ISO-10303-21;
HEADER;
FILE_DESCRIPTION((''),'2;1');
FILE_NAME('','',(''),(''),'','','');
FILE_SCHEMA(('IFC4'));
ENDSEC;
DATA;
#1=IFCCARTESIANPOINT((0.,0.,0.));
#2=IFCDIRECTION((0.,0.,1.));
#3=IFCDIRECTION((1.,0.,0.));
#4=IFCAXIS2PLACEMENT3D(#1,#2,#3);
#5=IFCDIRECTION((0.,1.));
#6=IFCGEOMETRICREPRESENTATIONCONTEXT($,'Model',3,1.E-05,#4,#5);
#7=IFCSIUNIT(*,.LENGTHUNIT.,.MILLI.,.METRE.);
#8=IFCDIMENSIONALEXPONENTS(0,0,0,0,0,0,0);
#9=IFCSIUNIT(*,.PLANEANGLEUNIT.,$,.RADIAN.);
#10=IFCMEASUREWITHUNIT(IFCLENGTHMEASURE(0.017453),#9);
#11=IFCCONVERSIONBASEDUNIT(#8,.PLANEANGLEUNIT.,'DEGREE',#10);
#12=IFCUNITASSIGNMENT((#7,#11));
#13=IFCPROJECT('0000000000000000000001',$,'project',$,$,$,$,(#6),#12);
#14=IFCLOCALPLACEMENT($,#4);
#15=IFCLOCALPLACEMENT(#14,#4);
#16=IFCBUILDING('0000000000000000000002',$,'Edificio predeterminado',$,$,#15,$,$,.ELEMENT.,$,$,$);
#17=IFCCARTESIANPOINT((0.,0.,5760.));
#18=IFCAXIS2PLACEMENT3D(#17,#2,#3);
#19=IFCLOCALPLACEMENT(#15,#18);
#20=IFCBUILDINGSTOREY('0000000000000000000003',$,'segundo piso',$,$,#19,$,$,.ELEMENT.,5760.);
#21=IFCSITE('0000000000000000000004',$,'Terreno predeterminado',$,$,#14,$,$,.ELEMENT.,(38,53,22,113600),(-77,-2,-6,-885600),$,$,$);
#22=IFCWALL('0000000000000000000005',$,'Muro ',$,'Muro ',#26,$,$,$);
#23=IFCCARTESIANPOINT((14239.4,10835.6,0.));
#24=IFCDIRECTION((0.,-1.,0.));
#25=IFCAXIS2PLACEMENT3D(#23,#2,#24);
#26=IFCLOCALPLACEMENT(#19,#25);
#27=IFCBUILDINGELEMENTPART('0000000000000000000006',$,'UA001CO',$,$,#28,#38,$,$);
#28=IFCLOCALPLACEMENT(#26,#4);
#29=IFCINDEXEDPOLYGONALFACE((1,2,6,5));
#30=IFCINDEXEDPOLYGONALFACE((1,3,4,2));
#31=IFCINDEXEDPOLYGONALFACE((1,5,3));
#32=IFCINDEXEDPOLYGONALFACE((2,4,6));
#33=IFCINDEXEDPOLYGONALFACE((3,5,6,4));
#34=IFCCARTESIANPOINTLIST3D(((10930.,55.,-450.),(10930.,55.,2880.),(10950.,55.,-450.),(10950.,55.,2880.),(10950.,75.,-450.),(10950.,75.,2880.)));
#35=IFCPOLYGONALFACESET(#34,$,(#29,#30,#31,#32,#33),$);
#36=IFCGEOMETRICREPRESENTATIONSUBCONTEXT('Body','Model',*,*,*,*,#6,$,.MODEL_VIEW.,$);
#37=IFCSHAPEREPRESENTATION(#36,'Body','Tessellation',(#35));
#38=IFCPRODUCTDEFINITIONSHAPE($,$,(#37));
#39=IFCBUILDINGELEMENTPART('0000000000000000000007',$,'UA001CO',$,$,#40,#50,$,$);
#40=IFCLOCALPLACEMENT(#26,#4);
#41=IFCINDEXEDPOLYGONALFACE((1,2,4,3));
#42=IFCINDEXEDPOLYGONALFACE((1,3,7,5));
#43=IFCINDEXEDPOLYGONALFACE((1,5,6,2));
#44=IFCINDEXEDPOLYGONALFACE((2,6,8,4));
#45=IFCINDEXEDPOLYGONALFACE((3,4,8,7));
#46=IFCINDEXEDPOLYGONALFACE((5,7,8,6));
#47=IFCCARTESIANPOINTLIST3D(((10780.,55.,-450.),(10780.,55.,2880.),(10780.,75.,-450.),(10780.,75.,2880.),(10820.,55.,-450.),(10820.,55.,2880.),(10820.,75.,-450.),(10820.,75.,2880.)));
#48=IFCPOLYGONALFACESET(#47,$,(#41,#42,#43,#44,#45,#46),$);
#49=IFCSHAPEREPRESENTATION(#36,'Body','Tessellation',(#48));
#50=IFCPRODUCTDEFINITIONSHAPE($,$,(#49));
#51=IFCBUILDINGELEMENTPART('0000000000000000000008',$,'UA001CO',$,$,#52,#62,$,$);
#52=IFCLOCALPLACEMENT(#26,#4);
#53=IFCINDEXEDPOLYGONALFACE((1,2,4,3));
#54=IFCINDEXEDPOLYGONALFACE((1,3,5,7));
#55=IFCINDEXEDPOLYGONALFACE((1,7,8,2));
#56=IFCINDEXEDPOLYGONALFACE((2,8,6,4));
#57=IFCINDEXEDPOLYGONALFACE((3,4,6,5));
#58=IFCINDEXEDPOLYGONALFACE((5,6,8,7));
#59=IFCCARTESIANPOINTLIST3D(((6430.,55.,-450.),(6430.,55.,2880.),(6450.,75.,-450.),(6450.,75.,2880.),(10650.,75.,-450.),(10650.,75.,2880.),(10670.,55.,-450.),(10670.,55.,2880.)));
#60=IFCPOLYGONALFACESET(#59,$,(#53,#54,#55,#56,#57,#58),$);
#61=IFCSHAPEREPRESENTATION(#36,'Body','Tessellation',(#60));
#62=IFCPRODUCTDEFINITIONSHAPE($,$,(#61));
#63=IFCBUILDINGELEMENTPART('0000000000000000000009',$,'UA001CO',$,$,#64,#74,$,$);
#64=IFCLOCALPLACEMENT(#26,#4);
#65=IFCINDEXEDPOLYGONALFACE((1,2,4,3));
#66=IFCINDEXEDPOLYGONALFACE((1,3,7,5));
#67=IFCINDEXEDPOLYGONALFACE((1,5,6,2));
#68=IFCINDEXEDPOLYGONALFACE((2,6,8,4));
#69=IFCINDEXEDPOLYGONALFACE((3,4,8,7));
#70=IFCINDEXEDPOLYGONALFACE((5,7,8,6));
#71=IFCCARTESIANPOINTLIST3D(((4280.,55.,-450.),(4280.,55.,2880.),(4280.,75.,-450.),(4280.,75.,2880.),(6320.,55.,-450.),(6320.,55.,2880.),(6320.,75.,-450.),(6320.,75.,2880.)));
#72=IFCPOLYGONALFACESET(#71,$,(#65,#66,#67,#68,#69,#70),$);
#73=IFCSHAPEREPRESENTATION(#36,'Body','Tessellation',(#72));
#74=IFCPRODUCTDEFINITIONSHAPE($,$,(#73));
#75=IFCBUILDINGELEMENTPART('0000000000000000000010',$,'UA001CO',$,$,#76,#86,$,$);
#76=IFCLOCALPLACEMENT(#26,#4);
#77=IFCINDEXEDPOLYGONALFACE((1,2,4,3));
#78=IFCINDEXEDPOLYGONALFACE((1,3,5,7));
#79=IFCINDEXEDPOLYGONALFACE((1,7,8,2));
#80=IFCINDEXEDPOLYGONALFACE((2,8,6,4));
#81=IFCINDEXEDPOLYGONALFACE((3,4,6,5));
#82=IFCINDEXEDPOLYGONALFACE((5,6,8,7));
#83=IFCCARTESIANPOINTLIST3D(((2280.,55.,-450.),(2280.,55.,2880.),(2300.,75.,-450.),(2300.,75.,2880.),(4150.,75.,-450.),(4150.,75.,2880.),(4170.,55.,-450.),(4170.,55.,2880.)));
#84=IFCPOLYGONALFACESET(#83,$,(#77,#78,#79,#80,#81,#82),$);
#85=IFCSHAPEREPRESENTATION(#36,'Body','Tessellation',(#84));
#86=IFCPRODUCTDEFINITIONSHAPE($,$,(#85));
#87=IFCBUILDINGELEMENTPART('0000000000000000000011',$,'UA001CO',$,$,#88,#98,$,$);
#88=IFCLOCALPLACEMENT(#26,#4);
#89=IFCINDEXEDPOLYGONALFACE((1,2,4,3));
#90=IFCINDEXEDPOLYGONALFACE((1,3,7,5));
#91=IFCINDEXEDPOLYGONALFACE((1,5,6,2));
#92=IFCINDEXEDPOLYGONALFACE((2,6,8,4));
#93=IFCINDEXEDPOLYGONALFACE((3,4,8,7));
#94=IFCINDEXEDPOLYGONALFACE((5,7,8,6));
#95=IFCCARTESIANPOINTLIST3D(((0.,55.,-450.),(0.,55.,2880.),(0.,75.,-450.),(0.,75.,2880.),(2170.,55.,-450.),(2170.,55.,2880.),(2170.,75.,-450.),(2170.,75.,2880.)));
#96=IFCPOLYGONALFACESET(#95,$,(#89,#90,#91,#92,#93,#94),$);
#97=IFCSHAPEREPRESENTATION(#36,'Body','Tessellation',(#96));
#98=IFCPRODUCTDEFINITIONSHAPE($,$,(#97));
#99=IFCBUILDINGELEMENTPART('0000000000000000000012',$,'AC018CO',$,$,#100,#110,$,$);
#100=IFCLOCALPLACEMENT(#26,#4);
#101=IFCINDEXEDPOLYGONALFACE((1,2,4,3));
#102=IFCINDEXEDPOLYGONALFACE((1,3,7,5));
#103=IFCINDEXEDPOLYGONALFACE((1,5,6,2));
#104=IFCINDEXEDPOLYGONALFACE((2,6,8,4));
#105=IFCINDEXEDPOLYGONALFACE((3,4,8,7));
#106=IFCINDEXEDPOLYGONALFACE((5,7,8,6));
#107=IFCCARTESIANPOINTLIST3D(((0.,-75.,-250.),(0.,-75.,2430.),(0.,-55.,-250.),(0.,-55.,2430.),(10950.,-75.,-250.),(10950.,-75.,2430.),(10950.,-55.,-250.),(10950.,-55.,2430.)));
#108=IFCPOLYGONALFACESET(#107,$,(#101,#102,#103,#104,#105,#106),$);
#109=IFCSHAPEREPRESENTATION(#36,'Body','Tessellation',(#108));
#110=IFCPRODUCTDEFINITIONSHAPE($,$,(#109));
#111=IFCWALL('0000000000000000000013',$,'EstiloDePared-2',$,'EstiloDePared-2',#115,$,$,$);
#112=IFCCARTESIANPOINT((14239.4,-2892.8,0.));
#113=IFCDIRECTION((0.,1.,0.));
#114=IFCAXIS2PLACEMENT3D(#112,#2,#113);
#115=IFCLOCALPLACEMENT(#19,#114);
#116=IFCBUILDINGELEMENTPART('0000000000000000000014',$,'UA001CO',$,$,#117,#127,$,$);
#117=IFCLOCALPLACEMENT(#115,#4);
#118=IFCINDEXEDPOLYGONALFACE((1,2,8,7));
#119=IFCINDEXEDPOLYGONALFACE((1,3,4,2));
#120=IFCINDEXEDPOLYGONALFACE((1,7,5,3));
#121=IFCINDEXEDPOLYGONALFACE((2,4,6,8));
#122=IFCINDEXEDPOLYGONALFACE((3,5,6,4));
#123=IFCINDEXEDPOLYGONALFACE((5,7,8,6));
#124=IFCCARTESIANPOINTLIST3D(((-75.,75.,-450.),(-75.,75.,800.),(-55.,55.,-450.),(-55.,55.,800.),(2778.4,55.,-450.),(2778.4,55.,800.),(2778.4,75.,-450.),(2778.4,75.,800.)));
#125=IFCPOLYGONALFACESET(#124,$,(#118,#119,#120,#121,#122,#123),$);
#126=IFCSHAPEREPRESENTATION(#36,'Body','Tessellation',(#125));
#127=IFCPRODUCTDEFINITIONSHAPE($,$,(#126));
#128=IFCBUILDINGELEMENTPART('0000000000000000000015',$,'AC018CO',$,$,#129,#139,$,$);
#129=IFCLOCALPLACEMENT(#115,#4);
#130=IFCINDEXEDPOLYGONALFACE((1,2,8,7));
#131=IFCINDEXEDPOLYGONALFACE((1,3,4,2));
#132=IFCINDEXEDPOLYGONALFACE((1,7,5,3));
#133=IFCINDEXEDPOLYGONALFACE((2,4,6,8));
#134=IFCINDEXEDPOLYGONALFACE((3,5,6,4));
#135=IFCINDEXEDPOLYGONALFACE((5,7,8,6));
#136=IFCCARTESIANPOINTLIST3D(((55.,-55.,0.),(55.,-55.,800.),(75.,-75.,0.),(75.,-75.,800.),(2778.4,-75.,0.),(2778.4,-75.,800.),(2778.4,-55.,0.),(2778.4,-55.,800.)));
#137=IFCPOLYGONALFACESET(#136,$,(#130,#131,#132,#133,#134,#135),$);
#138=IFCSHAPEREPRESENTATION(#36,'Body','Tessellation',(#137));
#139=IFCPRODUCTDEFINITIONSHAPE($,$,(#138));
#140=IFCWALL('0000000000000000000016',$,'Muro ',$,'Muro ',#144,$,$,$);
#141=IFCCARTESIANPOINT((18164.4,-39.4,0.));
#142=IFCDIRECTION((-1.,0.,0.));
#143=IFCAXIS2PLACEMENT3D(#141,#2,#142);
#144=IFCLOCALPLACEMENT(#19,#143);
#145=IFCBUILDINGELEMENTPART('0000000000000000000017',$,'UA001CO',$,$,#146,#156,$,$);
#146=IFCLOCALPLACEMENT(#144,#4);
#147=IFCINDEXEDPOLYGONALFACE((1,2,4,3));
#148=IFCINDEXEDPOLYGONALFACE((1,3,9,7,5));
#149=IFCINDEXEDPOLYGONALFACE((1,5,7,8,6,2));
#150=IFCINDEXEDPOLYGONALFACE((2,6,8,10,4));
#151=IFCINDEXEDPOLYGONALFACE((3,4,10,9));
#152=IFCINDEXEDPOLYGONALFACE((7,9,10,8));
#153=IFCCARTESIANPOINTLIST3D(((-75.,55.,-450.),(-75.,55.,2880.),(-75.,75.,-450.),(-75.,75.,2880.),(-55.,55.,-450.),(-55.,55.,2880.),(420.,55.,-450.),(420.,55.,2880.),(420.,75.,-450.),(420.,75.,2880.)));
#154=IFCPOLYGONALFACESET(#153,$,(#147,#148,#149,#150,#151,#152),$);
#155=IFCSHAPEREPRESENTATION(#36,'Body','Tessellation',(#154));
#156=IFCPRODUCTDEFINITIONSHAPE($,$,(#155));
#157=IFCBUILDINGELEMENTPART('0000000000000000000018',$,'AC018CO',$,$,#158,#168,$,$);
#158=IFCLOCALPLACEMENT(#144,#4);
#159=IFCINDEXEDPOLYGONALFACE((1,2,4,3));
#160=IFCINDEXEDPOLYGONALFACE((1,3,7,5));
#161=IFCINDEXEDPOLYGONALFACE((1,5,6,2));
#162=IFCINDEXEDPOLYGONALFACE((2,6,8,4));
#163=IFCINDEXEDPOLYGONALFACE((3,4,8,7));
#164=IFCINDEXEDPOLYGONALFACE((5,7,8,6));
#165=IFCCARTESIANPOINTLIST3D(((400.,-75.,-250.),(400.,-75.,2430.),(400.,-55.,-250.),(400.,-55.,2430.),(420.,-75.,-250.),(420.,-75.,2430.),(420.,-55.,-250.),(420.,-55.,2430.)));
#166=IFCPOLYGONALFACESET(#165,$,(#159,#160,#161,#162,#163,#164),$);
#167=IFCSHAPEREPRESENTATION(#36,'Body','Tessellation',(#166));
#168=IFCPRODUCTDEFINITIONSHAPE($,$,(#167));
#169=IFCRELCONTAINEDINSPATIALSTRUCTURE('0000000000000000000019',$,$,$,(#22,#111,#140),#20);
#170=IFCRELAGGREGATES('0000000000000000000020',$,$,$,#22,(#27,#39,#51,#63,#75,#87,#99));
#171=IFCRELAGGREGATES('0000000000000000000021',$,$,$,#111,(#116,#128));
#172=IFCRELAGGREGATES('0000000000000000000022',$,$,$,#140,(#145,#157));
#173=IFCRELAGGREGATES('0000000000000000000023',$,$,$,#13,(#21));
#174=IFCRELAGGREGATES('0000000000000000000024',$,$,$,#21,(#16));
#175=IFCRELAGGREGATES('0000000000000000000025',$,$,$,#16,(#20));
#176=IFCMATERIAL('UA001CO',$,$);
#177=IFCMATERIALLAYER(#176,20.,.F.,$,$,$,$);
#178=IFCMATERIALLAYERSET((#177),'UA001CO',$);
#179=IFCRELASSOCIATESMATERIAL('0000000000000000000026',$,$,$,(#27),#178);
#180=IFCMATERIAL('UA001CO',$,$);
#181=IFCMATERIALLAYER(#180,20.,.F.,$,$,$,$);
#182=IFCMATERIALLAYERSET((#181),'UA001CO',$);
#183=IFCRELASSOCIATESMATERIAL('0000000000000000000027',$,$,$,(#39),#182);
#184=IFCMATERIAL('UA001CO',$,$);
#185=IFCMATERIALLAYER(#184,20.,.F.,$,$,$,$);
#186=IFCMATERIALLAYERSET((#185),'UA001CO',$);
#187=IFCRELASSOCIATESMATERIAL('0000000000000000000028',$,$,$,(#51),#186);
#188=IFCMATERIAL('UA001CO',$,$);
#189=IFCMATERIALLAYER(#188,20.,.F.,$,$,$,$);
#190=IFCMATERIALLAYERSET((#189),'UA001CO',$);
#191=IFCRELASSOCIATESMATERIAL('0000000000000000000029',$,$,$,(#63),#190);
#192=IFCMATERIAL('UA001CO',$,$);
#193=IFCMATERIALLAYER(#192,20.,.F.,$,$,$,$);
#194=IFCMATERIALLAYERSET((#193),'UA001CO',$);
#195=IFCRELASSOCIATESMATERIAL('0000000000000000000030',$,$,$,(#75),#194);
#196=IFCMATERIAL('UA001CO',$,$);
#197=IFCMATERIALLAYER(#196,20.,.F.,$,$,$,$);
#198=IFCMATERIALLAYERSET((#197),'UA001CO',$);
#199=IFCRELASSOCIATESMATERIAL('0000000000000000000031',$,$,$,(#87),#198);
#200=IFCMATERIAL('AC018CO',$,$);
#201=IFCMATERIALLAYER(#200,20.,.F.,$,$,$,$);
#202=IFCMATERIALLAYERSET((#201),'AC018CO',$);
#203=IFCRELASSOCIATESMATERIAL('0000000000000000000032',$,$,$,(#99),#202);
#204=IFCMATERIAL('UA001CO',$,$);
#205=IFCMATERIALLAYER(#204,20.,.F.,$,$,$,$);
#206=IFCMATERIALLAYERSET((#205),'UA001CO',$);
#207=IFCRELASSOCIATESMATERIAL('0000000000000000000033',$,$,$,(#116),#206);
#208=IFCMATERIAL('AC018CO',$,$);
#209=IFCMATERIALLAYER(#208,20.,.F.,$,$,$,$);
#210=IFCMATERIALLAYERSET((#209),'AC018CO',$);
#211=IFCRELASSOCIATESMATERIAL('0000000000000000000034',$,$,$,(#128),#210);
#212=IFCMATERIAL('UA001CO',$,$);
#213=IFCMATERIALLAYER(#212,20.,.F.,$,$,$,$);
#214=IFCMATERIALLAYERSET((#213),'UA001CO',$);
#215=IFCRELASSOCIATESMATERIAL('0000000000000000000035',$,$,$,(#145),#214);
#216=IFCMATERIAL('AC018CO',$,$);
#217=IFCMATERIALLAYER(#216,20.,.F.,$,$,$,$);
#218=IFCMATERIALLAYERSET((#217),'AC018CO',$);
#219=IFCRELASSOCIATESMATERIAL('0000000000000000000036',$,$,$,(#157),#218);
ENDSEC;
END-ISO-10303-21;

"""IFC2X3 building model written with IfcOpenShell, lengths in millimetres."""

from ifc_helpers import new_model, entity, si_unit, converted_unit, direction, frame, origin_with_axes, place, context, subcontext, project, spatial, polyline, outline, extrude, material, layer, layer_set, layer_usage, element, aggregate, save


model = new_model("IFC2X3")

# Units and contexts
model_context = context("Model", 3, precision=1e-05, world=origin_with_axes(), true_north=direction((0.0, 1.0)))
body_context = subcontext(model_context, "Body", "Model", "MODEL_VIEW")
ifc_project = project(units=[si_unit("LENGTHUNIT", "METRE", prefix="MILLI"), converted_unit("PLANEANGLEUNIT", "DEGREE", entity("IfcLengthMeasure", 0.017453), si_unit("PLANEANGLEUNIT", "RADIAN"), dimensions=[0, 0, 0, 0, 0, 0, 0])], contexts=[model_context])

# Site, building, storey
site_placement = place(None, origin_with_axes())
site = spatial("IfcSite", under=ifc_project, at=site_placement, Name="Terreno predeterminado", CompositionType="ELEMENT", RefLatitude=(38, 53, 22, 113600), RefLongitude=(-77, -2, -6, -885600))
building_placement = place(site_placement, origin_with_axes())
building = spatial("IfcBuilding", under=site, at=building_placement, Name="Edificio predeterminado", CompositionType="ELEMENT")
storey_placement = place(building_placement, frame((0.0, 0.0, 5760.0), z_axis=(0.0, 0.0, 1.0), x_axis=(1.0, 0.0, 0.0)))
storey = spatial("IfcBuildingStorey", under=building, at=storey_placement, Name="segundo piso", CompositionType="ELEMENT", Elevation=5760.0)

# Walls, building element parts
wall_1_placement = place(storey_placement, frame((14239.4, 10835.6, 0.0), z_axis=(0.0, 0.0, 1.0), x_axis=(0.0, -1.0, 0.0)))
wall_1 = element("IfcWall", 1, at=wall_1_placement, inside=storey, Name="Muro ", ObjectType="Muro ")
ifc_material_1 = material(Name="UA001CO")
ifc_layer_1 = layer(ifc_material_1, 20.0, ventilated=False)
ifc_layer_set_1 = layer_set([ifc_layer_1], Name="UA001CO")
ifc_layer_usage_1 = layer_usage(ifc_layer_set_1, "AXIS2", "NEGATIVE", -75.0)
building_element_part_1_placement = place(wall_1_placement, origin_with_axes())
building_element_part_1 = element("IfcBuildingElementPart", 2, at=building_element_part_1_placement, material=ifc_layer_usage_1, Name="UA001CO", context=body_context, shape_type="SweptSolid", body=[
    extrude(outline(polyline([(10950.0, 75.0), (10950.0, 55.0), (10930.0, 55.0), (10950.0, 75.0)])), frame((0.0, 0.0, -450.0), z_axis=(0.0, 0.0, 1.0), x_axis=(1.0, 0.0, 0.0)), (0.0, 0.0, 1.0), 3330.0),
])
ifc_material_2 = material(Name="UA001CO")
ifc_layer_2 = layer(ifc_material_2, 20.0, ventilated=False)
ifc_layer_set_2 = layer_set([ifc_layer_2], Name="UA001CO")
ifc_layer_usage_2 = layer_usage(ifc_layer_set_2, "AXIS2", "NEGATIVE", -75.0)
building_element_part_2_placement = place(wall_1_placement, origin_with_axes())
building_element_part_2 = element("IfcBuildingElementPart", 3, at=building_element_part_2_placement, material=ifc_layer_usage_2, Name="UA001CO", context=body_context, shape_type="SweptSolid", body=[
    extrude(outline(polyline([(10820.0, 75.0), (10820.0, 55.0), (10780.0, 55.0), (10780.0, 75.0), (10820.0, 75.0)])), frame((0.0, 0.0, -450.0), z_axis=(0.0, 0.0, 1.0), x_axis=(1.0, 0.0, 0.0)), (0.0, 0.0, 1.0), 3330.0),
])
ifc_material_3 = material(Name="UA001CO")
ifc_layer_3 = layer(ifc_material_3, 20.0, ventilated=False)
ifc_layer_set_3 = layer_set([ifc_layer_3], Name="UA001CO")
ifc_layer_usage_3 = layer_usage(ifc_layer_set_3, "AXIS2", "NEGATIVE", -75.0)
building_element_part_3_placement = place(wall_1_placement, origin_with_axes())
building_element_part_3 = element("IfcBuildingElementPart", 4, at=building_element_part_3_placement, material=ifc_layer_usage_3, Name="UA001CO", context=body_context, shape_type="SweptSolid", body=[
    extrude(outline(polyline([(10650.0, 75.0), (10670.0, 55.0), (6430.0, 55.0), (6450.0, 75.0), (10650.0, 75.0)])), frame((0.0, 0.0, -450.0), z_axis=(0.0, 0.0, 1.0), x_axis=(1.0, 0.0, 0.0)), (0.0, 0.0, 1.0), 3330.0),
])
ifc_material_4 = material(Name="UA001CO")
ifc_layer_4 = layer(ifc_material_4, 20.0, ventilated=False)
ifc_layer_set_4 = layer_set([ifc_layer_4], Name="UA001CO")
ifc_layer_usage_4 = layer_usage(ifc_layer_set_4, "AXIS2", "NEGATIVE", -75.0)
building_element_part_4_placement = place(wall_1_placement, origin_with_axes())
building_element_part_4 = element("IfcBuildingElementPart", 5, at=building_element_part_4_placement, material=ifc_layer_usage_4, Name="UA001CO", context=body_context, shape_type="SweptSolid", body=[
    extrude(outline(polyline([(4280.0, 75.0), (6320.0, 75.0), (6320.0, 55.0), (4280.0, 55.0), (4280.0, 75.0)])), frame((0.0, 0.0, -450.0), z_axis=(0.0, 0.0, 1.0), x_axis=(1.0, 0.0, 0.0)), (0.0, 0.0, 1.0), 3330.0),
])
ifc_material_5 = material(Name="UA001CO")
ifc_layer_5 = layer(ifc_material_5, 20.0, ventilated=False)
ifc_layer_set_5 = layer_set([ifc_layer_5], Name="UA001CO")
ifc_layer_usage_5 = layer_usage(ifc_layer_set_5, "AXIS2", "NEGATIVE", -75.0)
building_element_part_5_placement = place(wall_1_placement, origin_with_axes())
building_element_part_5 = element("IfcBuildingElementPart", 6, at=building_element_part_5_placement, material=ifc_layer_usage_5, Name="UA001CO", context=body_context, shape_type="SweptSolid", body=[
    extrude(outline(polyline([(4150.0, 75.0), (4170.0, 55.0), (2280.0, 55.0), (2300.0, 75.0), (4150.0, 75.0)])), frame((0.0, 0.0, -450.0), z_axis=(0.0, 0.0, 1.0), x_axis=(1.0, 0.0, 0.0)), (0.0, 0.0, 1.0), 3330.0),
])
ifc_material_6 = material(Name="UA001CO")
ifc_layer_6 = layer(ifc_material_6, 20.0, ventilated=False)
ifc_layer_set_6 = layer_set([ifc_layer_6], Name="UA001CO")
ifc_layer_usage_6 = layer_usage(ifc_layer_set_6, "AXIS2", "NEGATIVE", -75.0)
building_element_part_6_placement = place(wall_1_placement, origin_with_axes())
building_element_part_6 = element("IfcBuildingElementPart", 7, at=building_element_part_6_placement, material=ifc_layer_usage_6, Name="UA001CO", context=body_context, shape_type="SweptSolid", body=[
    extrude(outline(polyline([(2170.0, 75.0), (2170.0, 55.0), (0.0, 55.0), (0.0, 75.0), (2170.0, 75.0)])), frame((0.0, 0.0, -450.0), z_axis=(0.0, 0.0, 1.0), x_axis=(1.0, 0.0, 0.0)), (0.0, 0.0, 1.0), 3330.0),
])
ifc_material_7 = material(Name="AC018CO")
ifc_layer_7 = layer(ifc_material_7, 20.0, ventilated=False)
ifc_layer_set_7 = layer_set([ifc_layer_7], Name="AC018CO")
ifc_layer_usage_7 = layer_usage(ifc_layer_set_7, "AXIS2", "NEGATIVE", 55.0)
building_element_part_7_placement = place(wall_1_placement, origin_with_axes())
building_element_part_7 = element("IfcBuildingElementPart", 8, at=building_element_part_7_placement, material=ifc_layer_usage_7, Name="AC018CO", context=body_context, shape_type="SweptSolid", body=[
    extrude(outline(polyline([(10950.0, -55.0), (10950.0, -75.0), (0.0, -75.0), (0.0, -55.0), (10950.0, -55.0)])), frame((0.0, 0.0, -250.0), z_axis=(0.0, 0.0, 1.0), x_axis=(1.0, 0.0, 0.0)), (0.0, 0.0, 1.0), 2680.0),
])
aggregate(wall_1, [building_element_part_1, building_element_part_2, building_element_part_3, building_element_part_4, building_element_part_5, building_element_part_6, building_element_part_7])
wall_2_placement = place(storey_placement, frame((14239.4, -2892.8, 0.0), z_axis=(0.0, 0.0, 1.0), x_axis=(0.0, 1.0, 0.0)))
wall_2 = element("IfcWall", 9, at=wall_2_placement, inside=storey, Name="EstiloDePared-2", ObjectType="EstiloDePared-2")
ifc_material_8 = material(Name="UA001CO")
ifc_layer_8 = layer(ifc_material_8, 20.0, ventilated=False)
ifc_layer_set_8 = layer_set([ifc_layer_8], Name="UA001CO")
ifc_layer_usage_8 = layer_usage(ifc_layer_set_8, "AXIS2", "NEGATIVE", -75.0)
building_element_part_8_placement = place(wall_2_placement, origin_with_axes())
building_element_part_8 = element("IfcBuildingElementPart", 10, at=building_element_part_8_placement, material=ifc_layer_usage_8, Name="UA001CO", context=body_context, shape_type="SweptSolid", body=[
    extrude(outline(polyline([(2778.4, 75.0), (2778.4, 55.0), (-55.0, 55.0), (-75.0, 75.0), (2778.4, 75.0)])), frame((0.0, 0.0, -450.0), z_axis=(0.0, 0.0, 1.0), x_axis=(1.0, 0.0, 0.0)), (0.0, 0.0, 1.0), 1250.0),
])
ifc_material_9 = material(Name="AC018CO")
ifc_layer_9 = layer(ifc_material_9, 20.0, ventilated=False)
ifc_layer_set_9 = layer_set([ifc_layer_9], Name="AC018CO")
ifc_layer_usage_9 = layer_usage(ifc_layer_set_9, "AXIS2", "NEGATIVE", 55.0)
building_element_part_9_placement = place(wall_2_placement, origin_with_axes())
building_element_part_9 = element("IfcBuildingElementPart", 11, at=building_element_part_9_placement, material=ifc_layer_usage_9, Name="AC018CO", context=body_context, shape_type="SweptSolid", body=[
    extrude(outline(polyline([(2778.4, -55.0), (2778.4, -75.0), (75.0, -75.0), (55.0, -55.0), (2778.4, -55.0)])), origin_with_axes(), (0.0, 0.0, 1.0), 800.0),
])
aggregate(wall_2, [building_element_part_8, building_element_part_9])
wall_3_placement = place(storey_placement, frame((18164.4, -39.4, 0.0), z_axis=(0.0, 0.0, 1.0), x_axis=(-1.0, 0.0, 0.0)))
wall_3 = element("IfcWall", 12, at=wall_3_placement, inside=storey, Name="Muro ", ObjectType="Muro ")
ifc_material_10 = material(Name="UA001CO")
ifc_layer_10 = layer(ifc_material_10, 20.0, ventilated=False)
ifc_layer_set_10 = layer_set([ifc_layer_10], Name="UA001CO")
ifc_layer_usage_10 = layer_usage(ifc_layer_set_10, "AXIS2", "NEGATIVE", -75.0)
building_element_part_10_placement = place(wall_3_placement, origin_with_axes())
building_element_part_10 = element("IfcBuildingElementPart", 13, at=building_element_part_10_placement, material=ifc_layer_usage_10, Name="UA001CO", context=body_context, shape_type="SweptSolid", body=[
    extrude(outline(polyline([(420.0, 75.0), (420.0, 55.0), (-55.0, 55.0), (-75.0, 55.0), (-75.0, 75.0), (420.0, 75.0)])), frame((0.0, 0.0, -450.0), z_axis=(0.0, 0.0, 1.0), x_axis=(1.0, 0.0, 0.0)), (0.0, 0.0, 1.0), 3330.0),
])
ifc_material_11 = material(Name="AC018CO")
ifc_layer_11 = layer(ifc_material_11, 20.0, ventilated=False)
ifc_layer_set_11 = layer_set([ifc_layer_11], Name="AC018CO")
ifc_layer_usage_11 = layer_usage(ifc_layer_set_11, "AXIS2", "NEGATIVE", 55.0)
building_element_part_11_placement = place(wall_3_placement, origin_with_axes())
building_element_part_11 = element("IfcBuildingElementPart", 14, at=building_element_part_11_placement, material=ifc_layer_usage_11, Name="AC018CO", context=body_context, shape_type="SweptSolid", body=[
    extrude(outline(polyline([(420.0, -55.0), (420.0, -75.0), (400.0, -75.0), (400.0, -55.0), (420.0, -55.0)])), frame((0.0, 0.0, -250.0), z_axis=(0.0, 0.0, 1.0), x_axis=(1.0, 0.0, 0.0)), (0.0, 0.0, 1.0), 2680.0),
])
aggregate(wall_3, [building_element_part_10, building_element_part_11])

save(model, "model.ifc")
